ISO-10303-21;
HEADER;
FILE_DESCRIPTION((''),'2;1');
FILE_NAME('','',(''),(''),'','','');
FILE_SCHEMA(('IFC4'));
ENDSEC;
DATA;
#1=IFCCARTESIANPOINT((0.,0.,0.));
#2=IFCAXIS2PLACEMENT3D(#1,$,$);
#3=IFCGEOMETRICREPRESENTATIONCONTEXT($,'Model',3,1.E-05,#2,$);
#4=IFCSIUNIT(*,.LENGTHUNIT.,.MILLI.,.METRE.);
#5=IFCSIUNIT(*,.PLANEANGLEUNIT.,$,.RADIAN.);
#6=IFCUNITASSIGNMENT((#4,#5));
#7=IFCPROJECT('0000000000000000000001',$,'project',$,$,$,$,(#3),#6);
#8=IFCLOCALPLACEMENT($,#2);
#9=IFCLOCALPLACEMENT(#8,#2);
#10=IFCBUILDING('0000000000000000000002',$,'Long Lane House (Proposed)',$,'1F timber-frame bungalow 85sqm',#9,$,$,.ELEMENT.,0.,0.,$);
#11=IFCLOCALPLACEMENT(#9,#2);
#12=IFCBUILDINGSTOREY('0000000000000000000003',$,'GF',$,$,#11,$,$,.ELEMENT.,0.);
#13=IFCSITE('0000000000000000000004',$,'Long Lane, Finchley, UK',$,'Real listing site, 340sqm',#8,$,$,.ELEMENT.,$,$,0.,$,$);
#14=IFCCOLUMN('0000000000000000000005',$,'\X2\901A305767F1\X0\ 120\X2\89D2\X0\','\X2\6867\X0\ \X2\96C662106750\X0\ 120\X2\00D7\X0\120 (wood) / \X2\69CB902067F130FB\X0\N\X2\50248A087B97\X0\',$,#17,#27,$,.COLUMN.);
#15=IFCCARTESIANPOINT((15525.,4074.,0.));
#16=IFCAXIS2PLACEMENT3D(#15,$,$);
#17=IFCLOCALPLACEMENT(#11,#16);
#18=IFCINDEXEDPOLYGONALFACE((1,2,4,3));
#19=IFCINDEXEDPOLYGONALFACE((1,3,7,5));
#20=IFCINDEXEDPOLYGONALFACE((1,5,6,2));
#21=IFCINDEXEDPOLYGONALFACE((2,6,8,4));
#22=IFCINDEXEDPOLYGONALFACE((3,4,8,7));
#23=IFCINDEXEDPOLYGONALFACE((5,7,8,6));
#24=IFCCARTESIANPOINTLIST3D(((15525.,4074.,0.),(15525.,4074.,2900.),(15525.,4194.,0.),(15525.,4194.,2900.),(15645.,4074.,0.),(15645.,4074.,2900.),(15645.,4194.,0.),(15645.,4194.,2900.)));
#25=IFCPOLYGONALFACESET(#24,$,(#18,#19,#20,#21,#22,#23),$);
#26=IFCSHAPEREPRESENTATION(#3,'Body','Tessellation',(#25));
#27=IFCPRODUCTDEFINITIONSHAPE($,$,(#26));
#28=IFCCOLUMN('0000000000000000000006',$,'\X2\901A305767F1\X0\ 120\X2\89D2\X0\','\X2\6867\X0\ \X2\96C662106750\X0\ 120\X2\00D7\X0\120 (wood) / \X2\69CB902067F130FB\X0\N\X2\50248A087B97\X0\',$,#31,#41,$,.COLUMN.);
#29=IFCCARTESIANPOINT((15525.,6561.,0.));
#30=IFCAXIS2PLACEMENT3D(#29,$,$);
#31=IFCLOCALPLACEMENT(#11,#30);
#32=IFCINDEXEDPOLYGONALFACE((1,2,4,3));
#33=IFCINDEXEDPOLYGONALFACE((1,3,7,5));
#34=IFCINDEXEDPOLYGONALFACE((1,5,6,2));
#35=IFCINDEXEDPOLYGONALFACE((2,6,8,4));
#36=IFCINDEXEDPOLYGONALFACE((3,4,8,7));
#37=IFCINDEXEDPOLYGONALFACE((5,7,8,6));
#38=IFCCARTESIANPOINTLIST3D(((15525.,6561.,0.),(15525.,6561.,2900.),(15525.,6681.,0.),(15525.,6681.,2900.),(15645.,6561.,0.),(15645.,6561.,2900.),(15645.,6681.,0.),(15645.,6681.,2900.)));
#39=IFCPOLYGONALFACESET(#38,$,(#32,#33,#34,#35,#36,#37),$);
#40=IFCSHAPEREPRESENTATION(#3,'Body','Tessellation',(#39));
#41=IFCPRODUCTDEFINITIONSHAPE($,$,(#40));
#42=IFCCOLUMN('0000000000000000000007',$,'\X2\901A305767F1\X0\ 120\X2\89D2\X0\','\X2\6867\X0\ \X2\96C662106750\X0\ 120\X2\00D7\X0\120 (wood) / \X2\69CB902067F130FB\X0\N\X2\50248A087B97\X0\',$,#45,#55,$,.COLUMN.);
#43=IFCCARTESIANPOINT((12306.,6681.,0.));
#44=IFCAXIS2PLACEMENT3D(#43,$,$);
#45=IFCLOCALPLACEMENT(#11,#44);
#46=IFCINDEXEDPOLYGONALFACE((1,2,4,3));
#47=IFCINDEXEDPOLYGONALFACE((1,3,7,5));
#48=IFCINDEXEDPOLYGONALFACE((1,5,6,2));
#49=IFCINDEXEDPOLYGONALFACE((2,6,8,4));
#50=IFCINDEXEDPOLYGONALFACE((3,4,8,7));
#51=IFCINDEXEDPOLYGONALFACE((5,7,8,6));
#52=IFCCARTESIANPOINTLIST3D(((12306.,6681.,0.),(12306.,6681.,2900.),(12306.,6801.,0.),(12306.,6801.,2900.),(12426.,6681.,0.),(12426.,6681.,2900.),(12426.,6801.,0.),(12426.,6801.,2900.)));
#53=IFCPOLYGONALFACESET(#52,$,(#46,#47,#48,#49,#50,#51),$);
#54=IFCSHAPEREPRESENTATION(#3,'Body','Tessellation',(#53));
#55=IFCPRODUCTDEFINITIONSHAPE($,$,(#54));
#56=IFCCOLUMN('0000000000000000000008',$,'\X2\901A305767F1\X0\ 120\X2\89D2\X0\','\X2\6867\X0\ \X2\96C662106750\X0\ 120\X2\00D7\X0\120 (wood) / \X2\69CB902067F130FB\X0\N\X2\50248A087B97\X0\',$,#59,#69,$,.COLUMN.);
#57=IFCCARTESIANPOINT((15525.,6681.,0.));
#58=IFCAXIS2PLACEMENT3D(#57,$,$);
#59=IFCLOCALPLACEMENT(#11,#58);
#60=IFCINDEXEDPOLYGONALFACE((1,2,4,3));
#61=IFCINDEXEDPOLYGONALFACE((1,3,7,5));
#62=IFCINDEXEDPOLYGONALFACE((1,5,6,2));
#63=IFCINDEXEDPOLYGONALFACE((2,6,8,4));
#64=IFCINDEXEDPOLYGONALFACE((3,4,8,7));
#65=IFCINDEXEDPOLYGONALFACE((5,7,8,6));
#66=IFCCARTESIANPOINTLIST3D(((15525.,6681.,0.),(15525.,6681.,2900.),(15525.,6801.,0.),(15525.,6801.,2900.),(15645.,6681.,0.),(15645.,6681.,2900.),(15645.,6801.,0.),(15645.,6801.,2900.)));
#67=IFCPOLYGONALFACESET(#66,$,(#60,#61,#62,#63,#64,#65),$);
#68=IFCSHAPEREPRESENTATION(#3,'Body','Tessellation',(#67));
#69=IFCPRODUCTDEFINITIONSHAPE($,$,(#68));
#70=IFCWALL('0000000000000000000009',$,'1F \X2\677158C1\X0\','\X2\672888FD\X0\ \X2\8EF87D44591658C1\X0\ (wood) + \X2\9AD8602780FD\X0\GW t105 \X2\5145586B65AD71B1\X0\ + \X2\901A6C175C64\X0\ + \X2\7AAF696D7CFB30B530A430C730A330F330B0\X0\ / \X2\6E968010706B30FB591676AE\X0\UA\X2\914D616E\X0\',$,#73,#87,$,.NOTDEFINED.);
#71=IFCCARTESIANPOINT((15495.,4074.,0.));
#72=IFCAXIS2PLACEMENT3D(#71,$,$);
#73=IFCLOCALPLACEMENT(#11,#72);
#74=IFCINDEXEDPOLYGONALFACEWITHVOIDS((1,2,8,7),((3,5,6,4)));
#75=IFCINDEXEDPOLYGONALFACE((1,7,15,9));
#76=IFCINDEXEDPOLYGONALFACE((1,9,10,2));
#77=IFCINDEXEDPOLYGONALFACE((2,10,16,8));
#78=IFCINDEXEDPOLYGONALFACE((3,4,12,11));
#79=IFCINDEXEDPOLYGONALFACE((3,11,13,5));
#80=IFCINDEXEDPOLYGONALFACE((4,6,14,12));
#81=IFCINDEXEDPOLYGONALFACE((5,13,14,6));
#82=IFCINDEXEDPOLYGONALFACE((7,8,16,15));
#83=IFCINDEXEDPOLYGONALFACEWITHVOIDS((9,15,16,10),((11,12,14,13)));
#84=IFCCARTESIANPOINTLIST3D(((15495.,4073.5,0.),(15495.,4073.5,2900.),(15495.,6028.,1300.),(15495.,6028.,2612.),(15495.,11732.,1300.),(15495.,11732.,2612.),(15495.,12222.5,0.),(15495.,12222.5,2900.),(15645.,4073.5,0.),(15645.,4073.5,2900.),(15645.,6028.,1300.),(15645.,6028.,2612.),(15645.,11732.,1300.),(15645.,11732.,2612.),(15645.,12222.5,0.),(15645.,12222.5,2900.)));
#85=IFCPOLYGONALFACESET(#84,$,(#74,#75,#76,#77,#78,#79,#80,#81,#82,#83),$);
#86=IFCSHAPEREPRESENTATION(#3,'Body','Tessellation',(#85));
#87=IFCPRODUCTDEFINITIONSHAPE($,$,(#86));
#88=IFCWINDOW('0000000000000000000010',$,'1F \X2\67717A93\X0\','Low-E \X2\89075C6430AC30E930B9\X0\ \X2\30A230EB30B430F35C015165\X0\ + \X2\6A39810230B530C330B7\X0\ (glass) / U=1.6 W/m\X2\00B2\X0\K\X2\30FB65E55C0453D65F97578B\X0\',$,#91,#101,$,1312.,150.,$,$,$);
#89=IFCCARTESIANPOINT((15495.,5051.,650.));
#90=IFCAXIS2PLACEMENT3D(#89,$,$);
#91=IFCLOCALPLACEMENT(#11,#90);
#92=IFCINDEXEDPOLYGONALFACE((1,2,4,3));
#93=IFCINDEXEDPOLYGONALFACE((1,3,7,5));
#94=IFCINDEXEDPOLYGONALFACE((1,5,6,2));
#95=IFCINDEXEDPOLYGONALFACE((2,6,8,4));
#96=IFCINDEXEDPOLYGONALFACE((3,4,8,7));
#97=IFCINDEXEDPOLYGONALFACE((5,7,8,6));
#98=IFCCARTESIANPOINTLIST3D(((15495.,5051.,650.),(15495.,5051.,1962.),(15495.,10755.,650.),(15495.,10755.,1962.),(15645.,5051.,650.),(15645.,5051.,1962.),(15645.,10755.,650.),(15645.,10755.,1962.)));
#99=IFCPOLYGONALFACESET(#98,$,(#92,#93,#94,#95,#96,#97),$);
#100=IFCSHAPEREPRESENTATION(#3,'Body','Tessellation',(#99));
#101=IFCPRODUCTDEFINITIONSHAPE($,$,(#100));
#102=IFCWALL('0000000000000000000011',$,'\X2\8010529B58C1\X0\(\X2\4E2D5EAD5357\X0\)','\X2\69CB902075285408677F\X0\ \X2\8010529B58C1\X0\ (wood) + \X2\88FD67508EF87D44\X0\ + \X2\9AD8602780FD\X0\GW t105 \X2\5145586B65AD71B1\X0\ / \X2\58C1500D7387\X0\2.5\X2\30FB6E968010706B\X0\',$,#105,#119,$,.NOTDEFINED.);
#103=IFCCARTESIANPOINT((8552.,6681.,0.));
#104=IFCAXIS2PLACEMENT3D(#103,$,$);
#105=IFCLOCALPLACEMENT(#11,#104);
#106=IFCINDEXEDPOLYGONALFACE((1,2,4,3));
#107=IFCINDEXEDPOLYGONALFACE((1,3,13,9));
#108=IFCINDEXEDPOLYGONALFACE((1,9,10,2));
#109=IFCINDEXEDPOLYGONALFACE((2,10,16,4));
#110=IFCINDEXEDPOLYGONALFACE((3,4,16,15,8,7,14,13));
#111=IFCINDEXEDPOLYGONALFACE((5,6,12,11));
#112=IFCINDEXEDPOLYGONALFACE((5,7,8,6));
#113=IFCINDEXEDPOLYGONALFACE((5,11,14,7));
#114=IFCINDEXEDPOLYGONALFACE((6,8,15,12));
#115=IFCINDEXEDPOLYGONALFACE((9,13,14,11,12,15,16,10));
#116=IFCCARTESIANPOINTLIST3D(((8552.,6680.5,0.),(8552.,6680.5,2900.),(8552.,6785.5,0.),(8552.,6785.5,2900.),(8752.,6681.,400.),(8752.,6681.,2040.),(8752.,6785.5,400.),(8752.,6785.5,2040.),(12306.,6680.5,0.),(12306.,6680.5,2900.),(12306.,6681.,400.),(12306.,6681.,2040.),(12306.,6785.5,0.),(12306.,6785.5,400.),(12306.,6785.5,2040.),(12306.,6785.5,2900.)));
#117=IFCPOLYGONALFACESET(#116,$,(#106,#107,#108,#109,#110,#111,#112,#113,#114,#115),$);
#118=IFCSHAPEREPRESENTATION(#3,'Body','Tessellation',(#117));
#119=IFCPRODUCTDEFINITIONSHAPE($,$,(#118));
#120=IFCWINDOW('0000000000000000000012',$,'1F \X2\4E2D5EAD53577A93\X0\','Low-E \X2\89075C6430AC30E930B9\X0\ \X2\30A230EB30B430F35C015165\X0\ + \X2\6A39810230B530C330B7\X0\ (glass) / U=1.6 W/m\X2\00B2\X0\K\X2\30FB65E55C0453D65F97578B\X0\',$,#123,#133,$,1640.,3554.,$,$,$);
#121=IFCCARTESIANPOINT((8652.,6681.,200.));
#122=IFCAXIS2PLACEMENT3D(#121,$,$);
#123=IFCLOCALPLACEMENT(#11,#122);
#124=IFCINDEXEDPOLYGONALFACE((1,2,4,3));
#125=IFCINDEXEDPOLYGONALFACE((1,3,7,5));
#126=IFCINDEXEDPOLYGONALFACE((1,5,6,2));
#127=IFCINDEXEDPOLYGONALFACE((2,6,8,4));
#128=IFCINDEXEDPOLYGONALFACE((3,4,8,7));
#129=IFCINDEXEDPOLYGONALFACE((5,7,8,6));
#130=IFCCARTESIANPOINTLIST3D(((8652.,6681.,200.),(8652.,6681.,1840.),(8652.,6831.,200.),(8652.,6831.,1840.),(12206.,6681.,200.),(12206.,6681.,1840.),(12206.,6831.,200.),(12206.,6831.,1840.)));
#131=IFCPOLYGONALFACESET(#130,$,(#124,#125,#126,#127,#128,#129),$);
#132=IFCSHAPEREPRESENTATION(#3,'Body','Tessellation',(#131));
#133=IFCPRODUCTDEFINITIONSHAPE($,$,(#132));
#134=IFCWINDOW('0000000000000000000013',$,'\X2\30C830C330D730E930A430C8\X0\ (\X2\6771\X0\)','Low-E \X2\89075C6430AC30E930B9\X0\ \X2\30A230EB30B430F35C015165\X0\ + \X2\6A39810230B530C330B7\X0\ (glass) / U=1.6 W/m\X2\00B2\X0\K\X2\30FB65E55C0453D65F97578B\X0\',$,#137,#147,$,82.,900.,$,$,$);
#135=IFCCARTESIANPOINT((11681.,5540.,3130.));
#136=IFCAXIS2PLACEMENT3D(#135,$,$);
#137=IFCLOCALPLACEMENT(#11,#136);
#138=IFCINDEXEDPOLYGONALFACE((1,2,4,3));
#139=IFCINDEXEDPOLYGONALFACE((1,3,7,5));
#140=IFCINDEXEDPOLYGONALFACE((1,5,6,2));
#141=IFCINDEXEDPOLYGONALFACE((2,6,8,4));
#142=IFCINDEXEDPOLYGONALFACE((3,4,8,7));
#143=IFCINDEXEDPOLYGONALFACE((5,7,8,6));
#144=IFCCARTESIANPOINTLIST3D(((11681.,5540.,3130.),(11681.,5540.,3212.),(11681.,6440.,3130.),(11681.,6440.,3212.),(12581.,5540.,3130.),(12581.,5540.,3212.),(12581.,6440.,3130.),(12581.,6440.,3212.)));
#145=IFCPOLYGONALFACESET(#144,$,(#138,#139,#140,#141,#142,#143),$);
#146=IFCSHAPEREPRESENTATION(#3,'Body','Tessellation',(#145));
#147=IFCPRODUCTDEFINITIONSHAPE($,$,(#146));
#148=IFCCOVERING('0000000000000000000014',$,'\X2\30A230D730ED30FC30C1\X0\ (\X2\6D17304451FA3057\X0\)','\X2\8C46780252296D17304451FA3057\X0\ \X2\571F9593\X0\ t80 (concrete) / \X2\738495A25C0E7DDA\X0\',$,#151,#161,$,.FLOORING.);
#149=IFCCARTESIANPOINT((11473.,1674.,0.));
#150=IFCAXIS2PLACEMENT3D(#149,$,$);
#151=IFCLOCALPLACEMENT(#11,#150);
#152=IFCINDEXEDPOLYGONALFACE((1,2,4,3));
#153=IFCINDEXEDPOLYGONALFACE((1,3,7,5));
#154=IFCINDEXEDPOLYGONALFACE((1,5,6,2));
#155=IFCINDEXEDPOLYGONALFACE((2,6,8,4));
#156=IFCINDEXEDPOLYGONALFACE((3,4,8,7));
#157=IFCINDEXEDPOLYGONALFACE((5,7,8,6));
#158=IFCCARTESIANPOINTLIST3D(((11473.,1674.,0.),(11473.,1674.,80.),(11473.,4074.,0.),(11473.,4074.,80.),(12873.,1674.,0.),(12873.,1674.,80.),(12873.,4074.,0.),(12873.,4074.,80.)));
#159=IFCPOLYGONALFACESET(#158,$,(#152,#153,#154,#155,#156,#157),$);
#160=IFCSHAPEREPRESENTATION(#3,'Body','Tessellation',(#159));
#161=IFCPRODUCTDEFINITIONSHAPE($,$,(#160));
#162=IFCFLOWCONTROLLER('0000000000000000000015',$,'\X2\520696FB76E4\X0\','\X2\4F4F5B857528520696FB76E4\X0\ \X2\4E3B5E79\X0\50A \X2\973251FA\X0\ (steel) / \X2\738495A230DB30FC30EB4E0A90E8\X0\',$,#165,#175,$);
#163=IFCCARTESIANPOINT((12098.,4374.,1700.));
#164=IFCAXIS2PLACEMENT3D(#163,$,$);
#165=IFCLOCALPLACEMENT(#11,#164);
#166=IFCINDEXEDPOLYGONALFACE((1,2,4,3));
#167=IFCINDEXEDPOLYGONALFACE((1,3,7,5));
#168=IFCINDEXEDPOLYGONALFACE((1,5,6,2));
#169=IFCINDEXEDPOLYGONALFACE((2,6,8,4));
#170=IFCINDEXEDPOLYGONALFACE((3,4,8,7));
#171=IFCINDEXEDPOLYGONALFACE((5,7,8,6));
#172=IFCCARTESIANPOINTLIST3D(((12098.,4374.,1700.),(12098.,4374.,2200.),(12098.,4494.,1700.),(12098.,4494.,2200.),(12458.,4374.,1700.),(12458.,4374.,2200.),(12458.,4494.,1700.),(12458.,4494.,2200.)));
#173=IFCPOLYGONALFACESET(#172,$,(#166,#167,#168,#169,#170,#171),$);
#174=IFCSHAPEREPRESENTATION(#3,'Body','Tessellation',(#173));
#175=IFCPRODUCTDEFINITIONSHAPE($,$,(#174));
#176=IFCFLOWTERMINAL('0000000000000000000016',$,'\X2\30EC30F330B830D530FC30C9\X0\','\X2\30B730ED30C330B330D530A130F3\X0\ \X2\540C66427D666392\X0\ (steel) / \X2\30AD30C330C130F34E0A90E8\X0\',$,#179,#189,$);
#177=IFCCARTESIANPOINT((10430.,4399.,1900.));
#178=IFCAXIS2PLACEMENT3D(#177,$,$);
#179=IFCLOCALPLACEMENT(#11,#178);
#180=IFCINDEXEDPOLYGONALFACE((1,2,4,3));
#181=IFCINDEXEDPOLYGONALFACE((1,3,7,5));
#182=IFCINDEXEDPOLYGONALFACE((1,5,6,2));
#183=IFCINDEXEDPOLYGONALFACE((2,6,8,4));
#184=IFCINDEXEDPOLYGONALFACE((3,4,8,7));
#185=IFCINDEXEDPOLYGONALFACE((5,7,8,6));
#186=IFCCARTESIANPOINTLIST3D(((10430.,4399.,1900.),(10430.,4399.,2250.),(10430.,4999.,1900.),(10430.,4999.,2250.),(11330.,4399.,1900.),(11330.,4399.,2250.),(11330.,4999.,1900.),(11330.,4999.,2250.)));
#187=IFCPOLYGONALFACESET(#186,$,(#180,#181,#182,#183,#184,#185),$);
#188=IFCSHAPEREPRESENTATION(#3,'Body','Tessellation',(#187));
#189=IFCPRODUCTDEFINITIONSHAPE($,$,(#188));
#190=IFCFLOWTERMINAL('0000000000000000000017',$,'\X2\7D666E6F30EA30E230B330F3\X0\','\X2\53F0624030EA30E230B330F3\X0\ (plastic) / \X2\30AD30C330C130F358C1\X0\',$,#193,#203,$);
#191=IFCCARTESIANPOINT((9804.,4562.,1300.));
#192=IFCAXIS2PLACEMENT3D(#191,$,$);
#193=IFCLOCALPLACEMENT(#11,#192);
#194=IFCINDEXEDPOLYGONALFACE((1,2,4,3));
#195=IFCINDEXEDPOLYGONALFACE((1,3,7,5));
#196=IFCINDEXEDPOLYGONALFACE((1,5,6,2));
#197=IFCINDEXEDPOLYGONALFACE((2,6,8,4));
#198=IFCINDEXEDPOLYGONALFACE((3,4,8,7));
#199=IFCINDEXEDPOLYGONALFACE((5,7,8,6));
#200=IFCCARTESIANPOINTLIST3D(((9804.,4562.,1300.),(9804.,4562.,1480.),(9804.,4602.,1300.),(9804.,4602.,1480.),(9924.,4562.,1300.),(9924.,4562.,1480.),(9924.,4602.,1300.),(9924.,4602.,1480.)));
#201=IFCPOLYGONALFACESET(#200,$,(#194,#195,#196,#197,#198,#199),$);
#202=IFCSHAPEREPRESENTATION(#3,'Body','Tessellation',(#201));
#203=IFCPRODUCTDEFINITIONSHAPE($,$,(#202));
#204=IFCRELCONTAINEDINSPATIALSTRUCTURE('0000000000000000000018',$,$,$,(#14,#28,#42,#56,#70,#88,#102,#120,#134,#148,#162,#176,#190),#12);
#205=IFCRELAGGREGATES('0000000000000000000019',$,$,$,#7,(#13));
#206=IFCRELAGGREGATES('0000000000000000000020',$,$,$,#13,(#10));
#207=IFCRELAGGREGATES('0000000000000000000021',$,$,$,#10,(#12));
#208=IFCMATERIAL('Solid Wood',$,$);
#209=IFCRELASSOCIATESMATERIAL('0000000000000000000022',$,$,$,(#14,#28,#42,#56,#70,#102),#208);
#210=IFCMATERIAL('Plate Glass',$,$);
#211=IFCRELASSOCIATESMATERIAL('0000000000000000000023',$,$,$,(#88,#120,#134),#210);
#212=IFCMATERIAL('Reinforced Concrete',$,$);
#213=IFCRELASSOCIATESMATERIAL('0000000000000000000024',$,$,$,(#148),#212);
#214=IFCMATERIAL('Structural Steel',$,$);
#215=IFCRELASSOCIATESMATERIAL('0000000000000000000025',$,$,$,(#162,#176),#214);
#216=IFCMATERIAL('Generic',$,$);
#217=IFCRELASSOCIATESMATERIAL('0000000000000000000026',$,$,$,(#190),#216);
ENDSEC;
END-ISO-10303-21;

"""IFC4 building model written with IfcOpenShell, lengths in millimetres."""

from ifc_helpers import new_model, si_unit, frame, frame_2d, origin, place, context, project, spatial, rectangle, extrude, material, element, fill, save


model = new_model("IFC4")

# Units and contexts
model_context = context("Model", 3, precision=1e-05, world=origin())
ifc_project = project(units=[si_unit("LENGTHUNIT", "METRE", prefix="MILLI"), si_unit("PLANEANGLEUNIT", "RADIAN")], contexts=[model_context])

# Site, building, storey
site_placement = place(None, origin())
site = spatial("IfcSite", under=ifc_project, at=site_placement, Name="Long Lane, Finchley, UK", ObjectType="Real listing site, 340sqm", CompositionType="ELEMENT", RefElevation=0.0)
building_placement = place(site_placement, origin())
building = spatial("IfcBuilding", under=site, at=building_placement, Name="Long Lane House (Proposed)", ObjectType="1F timber-frame bungalow 85sqm", CompositionType="ELEMENT", ElevationOfRefHeight=0.0, ElevationOfTerrain=0.0)
storey_placement = place(building_placement, origin())
storey = spatial("IfcBuildingStorey", under=building, at=storey_placement, Name="GF", CompositionType="ELEMENT", Elevation=0.0)

# Columns
ifc_material_1 = material(Name="Solid Wood")
column_1_placement = place(storey_placement, frame((15525.0, 4074.0, 0.0)))
element("IfcColumn", 1, at=column_1_placement, inside=storey, material=ifc_material_1, Name="通し柱 120角", Description="桧 集成材 120×120 (wood) / 構造柱・N値計算", PredefinedType="COLUMN", context=model_context, shape_type="SweptSolid", body=[
    extrude(rectangle(XDim=120.0, YDim=120.0, at=frame_2d((60.0, 60.0))), frame((15525.0, 4074.0, 0.0)), (0.0, 0.0, 1.0), 2900.0),
])
column_2_placement = place(storey_placement, frame((15525.0, 6561.0, 0.0)))
element("IfcColumn", 2, at=column_2_placement, inside=storey, material=ifc_material_1, Name="通し柱 120角", Description="桧 集成材 120×120 (wood) / 構造柱・N値計算", PredefinedType="COLUMN", context=model_context, shape_type="SweptSolid", body=[
    extrude(rectangle(XDim=120.0, YDim=120.0, at=frame_2d((60.0, 60.0))), frame((15525.0, 6561.0, 0.0)), (0.0, 0.0, 1.0), 2900.0),
])
column_3_placement = place(storey_placement, frame((12306.0, 6681.0, 0.0)))
element("IfcColumn", 3, at=column_3_placement, inside=storey, material=ifc_material_1, Name="通し柱 120角", Description="桧 集成材 120×120 (wood) / 構造柱・N値計算", PredefinedType="COLUMN", context=model_context, shape_type="SweptSolid", body=[
    extrude(rectangle(XDim=120.0, YDim=120.0, at=frame_2d((60.0, 60.0))), frame((12306.0, 6681.0, 0.0)), (0.0, 0.0, 1.0), 2900.0),
])
column_4_placement = place(storey_placement, frame((15525.0, 6681.0, 0.0)))
element("IfcColumn", 4, at=column_4_placement, inside=storey, material=ifc_material_1, Name="通し柱 120角", Description="桧 集成材 120×120 (wood) / 構造柱・N値計算", PredefinedType="COLUMN", context=model_context, shape_type="SweptSolid", body=[
    extrude(rectangle(XDim=120.0, YDim=120.0, at=frame_2d((60.0, 60.0))), frame((15525.0, 6681.0, 0.0)), (0.0, 0.0, 1.0), 2900.0),
])

# Walls, openings, windows
wall_1_placement = place(storey_placement, frame((15495.0, 4074.0, 0.0)))
wall_1 = element("IfcWall", 5, at=wall_1_placement, inside=storey, material=ifc_material_1, Name="1F 東壁", Description="木製 軸組外壁 (wood) + 高性能GW t105 充填断熱 + 通気層 + 窯業系サイディング / 準耐火・外皮UA配慮", PredefinedType="NOTDEFINED", context=model_context, shape_type="SweptSolid", body=[
    extrude(rectangle(XDim=150.0, YDim=8149.0, at=frame_2d((75.0, 4074.0))), frame((15495.0, 4074.0, 0.0)), (0.0, 0.0, 1.0), 2900.0),
])
opening_1_placement = place(storey_placement, frame((15495.0, 5051.0, 650.0)))
opening_1 = element("IfcOpeningElement", 6, at=opening_1_placement, cuts=wall_1, PredefinedType="NOTDEFINED", context=model_context, shape_type="SweptSolid", body=[
    extrude(rectangle(XDim=150.0, YDim=5704.0, at=frame_2d((75.0, 2852.0))), frame((15495.0, 5051.0, 650.0)), (0.0, 0.0, 1.0), 1312.0),
])
ifc_material_2 = material(Name="Plate Glass")
window_1_placement = place(storey_placement, frame((15495.0, 5051.0, 650.0)))
window_1 = element("IfcWindow", 7, at=window_1_placement, inside=storey, material=ifc_material_2, Name="1F 東窓", Description="Low-E 複層ガラス アルゴン封入 + 樹脂サッシ (glass) / U=1.6 W/m²K・日射取得型", OverallHeight=1312.0, OverallWidth=150.0, context=model_context, shape_type="SweptSolid", body=[
    extrude(rectangle(XDim=150.0, YDim=5704.0, at=frame_2d((75.0, 2852.0))), frame((15495.0, 5051.0, 650.0)), (0.0, 0.0, 1.0), 1312.0),
])
fill(opening_1, window_1)
wall_2_placement = place(storey_placement, frame((8552.0, 6681.0, 0.0)))
wall_2 = element("IfcWall", 8, at=wall_2_placement, inside=storey, material=ifc_material_1, Name="耐力壁(中庭南)", Description="構造用合板 耐力壁 (wood) + 製材軸組 + 高性能GW t105 充填断熱 / 壁倍率2.5・準耐火", PredefinedType="NOTDEFINED", context=model_context, shape_type="SweptSolid", body=[
    extrude(rectangle(XDim=3754.0, YDim=105.0, at=frame_2d((1877.0, 52.0))), frame((8552.0, 6681.0, 0.0)), (0.0, 0.0, 1.0), 2900.0),
])
opening_2_placement = place(storey_placement, frame((8652.0, 6681.0, 200.0)))
opening_2 = element("IfcOpeningElement", 9, at=opening_2_placement, cuts=wall_2, PredefinedType="NOTDEFINED", context=model_context, shape_type="SweptSolid", body=[
    extrude(rectangle(XDim=3554.0, YDim=150.0, at=frame_2d((1777.0, 75.0))), frame((8652.0, 6681.0, 200.0)), (0.0, 0.0, 1.0), 1640.0),
])
window_2_placement = place(storey_placement, frame((8652.0, 6681.0, 200.0)))
window_2 = element("IfcWindow", 10, at=window_2_placement, inside=storey, material=ifc_material_2, Name="1F 中庭南窓", Description="Low-E 複層ガラス アルゴン封入 + 樹脂サッシ (glass) / U=1.6 W/m²K・日射取得型", OverallHeight=1640.0, OverallWidth=3554.0, context=model_context, shape_type="SweptSolid", body=[
    extrude(rectangle(XDim=3554.0, YDim=150.0, at=frame_2d((1777.0, 75.0))), frame((8652.0, 6681.0, 200.0)), (0.0, 0.0, 1.0), 1640.0),
])
fill(opening_2, window_2)

# Window
window_3_placement = place(storey_placement, frame((11681.0, 5540.0, 3130.0)))
element("IfcWindow", 11, at=window_3_placement, inside=storey, material=ifc_material_2, Name="トップライト (東)", Description="Low-E 複層ガラス アルゴン封入 + 樹脂サッシ (glass) / U=1.6 W/m²K・日射取得型", OverallHeight=82.0, OverallWidth=900.0, context=model_context, shape_type="SweptSolid", body=[
    extrude(rectangle(XDim=900.0, YDim=900.0, at=frame_2d((450.0, 450.0))), frame((11681.0, 5540.0, 3130.0)), (0.0, 0.0, 1.0), 82.0),
])

# Shared definitions
ifc_material_3 = material(Name="Structural Steel")

# Covering
ifc_material_4 = material(Name="Reinforced Concrete")
covering_placement = place(storey_placement, frame((11473.0, 1674.0, 0.0)))
element("IfcCovering", 12, at=covering_placement, inside=storey, material=ifc_material_4, Name="アプローチ (洗い出し)", Description="豆砂利洗い出し 土間 t80 (concrete) / 玄関導線", PredefinedType="FLOORING", context=model_context, shape_type="SweptSolid", body=[
    extrude(rectangle(XDim=1400.0, YDim=2400.0, at=frame_2d((700.0, 1200.0))), frame((11473.0, 1674.0, 0.0)), (0.0, 0.0, 1.0), 80.0),
])

# Flow controller
flow_controller_placement = place(storey_placement, frame((12098.0, 4374.0, 1700.0)))
element("IfcFlowController", 13, at=flow_controller_placement, inside=storey, material=ifc_material_3, Name="分電盤", Description="住宅用分電盤 主幹50A 露出 (steel) / 玄関ホール上部", context=model_context, shape_type="SweptSolid", body=[
    extrude(rectangle(XDim=360.0, YDim=120.0, at=frame_2d((180.0, 60.0))), frame((12098.0, 4374.0, 1700.0)), (0.0, 0.0, 1.0), 500.0),
])

# Flow terminals
flow_terminal_1_placement = place(storey_placement, frame((10430.0, 4399.0, 1900.0)))
element("IfcFlowTerminal", 14, at=flow_terminal_1_placement, inside=storey, material=ifc_material_3, Name="レンジフード", Description="シロッコファン 同時給排 (steel) / キッチン上部", context=model_context, shape_type="SweptSolid", body=[
    extrude(rectangle(XDim=900.0, YDim=600.0, at=frame_2d((450.0, 300.0))), frame((10430.0, 4399.0, 1900.0)), (0.0, 0.0, 1.0), 350.0),
])
ifc_material_5 = material(Name="Generic")
flow_terminal_2_placement = place(storey_placement, frame((9804.0, 4562.0, 1300.0)))
element("IfcFlowTerminal", 15, at=flow_terminal_2_placement, inside=storey, material=ifc_material_5, Name="給湯リモコン", Description="台所リモコン (plastic) / キッチン壁", context=model_context, shape_type="SweptSolid", body=[
    extrude(rectangle(XDim=120.0, YDim=40.0, at=frame_2d((60.0, 20.0))), frame((9804.0, 4562.0, 1300.0)), (0.0, 0.0, 1.0), 180.0),
])

save(model, "model.ifc")
